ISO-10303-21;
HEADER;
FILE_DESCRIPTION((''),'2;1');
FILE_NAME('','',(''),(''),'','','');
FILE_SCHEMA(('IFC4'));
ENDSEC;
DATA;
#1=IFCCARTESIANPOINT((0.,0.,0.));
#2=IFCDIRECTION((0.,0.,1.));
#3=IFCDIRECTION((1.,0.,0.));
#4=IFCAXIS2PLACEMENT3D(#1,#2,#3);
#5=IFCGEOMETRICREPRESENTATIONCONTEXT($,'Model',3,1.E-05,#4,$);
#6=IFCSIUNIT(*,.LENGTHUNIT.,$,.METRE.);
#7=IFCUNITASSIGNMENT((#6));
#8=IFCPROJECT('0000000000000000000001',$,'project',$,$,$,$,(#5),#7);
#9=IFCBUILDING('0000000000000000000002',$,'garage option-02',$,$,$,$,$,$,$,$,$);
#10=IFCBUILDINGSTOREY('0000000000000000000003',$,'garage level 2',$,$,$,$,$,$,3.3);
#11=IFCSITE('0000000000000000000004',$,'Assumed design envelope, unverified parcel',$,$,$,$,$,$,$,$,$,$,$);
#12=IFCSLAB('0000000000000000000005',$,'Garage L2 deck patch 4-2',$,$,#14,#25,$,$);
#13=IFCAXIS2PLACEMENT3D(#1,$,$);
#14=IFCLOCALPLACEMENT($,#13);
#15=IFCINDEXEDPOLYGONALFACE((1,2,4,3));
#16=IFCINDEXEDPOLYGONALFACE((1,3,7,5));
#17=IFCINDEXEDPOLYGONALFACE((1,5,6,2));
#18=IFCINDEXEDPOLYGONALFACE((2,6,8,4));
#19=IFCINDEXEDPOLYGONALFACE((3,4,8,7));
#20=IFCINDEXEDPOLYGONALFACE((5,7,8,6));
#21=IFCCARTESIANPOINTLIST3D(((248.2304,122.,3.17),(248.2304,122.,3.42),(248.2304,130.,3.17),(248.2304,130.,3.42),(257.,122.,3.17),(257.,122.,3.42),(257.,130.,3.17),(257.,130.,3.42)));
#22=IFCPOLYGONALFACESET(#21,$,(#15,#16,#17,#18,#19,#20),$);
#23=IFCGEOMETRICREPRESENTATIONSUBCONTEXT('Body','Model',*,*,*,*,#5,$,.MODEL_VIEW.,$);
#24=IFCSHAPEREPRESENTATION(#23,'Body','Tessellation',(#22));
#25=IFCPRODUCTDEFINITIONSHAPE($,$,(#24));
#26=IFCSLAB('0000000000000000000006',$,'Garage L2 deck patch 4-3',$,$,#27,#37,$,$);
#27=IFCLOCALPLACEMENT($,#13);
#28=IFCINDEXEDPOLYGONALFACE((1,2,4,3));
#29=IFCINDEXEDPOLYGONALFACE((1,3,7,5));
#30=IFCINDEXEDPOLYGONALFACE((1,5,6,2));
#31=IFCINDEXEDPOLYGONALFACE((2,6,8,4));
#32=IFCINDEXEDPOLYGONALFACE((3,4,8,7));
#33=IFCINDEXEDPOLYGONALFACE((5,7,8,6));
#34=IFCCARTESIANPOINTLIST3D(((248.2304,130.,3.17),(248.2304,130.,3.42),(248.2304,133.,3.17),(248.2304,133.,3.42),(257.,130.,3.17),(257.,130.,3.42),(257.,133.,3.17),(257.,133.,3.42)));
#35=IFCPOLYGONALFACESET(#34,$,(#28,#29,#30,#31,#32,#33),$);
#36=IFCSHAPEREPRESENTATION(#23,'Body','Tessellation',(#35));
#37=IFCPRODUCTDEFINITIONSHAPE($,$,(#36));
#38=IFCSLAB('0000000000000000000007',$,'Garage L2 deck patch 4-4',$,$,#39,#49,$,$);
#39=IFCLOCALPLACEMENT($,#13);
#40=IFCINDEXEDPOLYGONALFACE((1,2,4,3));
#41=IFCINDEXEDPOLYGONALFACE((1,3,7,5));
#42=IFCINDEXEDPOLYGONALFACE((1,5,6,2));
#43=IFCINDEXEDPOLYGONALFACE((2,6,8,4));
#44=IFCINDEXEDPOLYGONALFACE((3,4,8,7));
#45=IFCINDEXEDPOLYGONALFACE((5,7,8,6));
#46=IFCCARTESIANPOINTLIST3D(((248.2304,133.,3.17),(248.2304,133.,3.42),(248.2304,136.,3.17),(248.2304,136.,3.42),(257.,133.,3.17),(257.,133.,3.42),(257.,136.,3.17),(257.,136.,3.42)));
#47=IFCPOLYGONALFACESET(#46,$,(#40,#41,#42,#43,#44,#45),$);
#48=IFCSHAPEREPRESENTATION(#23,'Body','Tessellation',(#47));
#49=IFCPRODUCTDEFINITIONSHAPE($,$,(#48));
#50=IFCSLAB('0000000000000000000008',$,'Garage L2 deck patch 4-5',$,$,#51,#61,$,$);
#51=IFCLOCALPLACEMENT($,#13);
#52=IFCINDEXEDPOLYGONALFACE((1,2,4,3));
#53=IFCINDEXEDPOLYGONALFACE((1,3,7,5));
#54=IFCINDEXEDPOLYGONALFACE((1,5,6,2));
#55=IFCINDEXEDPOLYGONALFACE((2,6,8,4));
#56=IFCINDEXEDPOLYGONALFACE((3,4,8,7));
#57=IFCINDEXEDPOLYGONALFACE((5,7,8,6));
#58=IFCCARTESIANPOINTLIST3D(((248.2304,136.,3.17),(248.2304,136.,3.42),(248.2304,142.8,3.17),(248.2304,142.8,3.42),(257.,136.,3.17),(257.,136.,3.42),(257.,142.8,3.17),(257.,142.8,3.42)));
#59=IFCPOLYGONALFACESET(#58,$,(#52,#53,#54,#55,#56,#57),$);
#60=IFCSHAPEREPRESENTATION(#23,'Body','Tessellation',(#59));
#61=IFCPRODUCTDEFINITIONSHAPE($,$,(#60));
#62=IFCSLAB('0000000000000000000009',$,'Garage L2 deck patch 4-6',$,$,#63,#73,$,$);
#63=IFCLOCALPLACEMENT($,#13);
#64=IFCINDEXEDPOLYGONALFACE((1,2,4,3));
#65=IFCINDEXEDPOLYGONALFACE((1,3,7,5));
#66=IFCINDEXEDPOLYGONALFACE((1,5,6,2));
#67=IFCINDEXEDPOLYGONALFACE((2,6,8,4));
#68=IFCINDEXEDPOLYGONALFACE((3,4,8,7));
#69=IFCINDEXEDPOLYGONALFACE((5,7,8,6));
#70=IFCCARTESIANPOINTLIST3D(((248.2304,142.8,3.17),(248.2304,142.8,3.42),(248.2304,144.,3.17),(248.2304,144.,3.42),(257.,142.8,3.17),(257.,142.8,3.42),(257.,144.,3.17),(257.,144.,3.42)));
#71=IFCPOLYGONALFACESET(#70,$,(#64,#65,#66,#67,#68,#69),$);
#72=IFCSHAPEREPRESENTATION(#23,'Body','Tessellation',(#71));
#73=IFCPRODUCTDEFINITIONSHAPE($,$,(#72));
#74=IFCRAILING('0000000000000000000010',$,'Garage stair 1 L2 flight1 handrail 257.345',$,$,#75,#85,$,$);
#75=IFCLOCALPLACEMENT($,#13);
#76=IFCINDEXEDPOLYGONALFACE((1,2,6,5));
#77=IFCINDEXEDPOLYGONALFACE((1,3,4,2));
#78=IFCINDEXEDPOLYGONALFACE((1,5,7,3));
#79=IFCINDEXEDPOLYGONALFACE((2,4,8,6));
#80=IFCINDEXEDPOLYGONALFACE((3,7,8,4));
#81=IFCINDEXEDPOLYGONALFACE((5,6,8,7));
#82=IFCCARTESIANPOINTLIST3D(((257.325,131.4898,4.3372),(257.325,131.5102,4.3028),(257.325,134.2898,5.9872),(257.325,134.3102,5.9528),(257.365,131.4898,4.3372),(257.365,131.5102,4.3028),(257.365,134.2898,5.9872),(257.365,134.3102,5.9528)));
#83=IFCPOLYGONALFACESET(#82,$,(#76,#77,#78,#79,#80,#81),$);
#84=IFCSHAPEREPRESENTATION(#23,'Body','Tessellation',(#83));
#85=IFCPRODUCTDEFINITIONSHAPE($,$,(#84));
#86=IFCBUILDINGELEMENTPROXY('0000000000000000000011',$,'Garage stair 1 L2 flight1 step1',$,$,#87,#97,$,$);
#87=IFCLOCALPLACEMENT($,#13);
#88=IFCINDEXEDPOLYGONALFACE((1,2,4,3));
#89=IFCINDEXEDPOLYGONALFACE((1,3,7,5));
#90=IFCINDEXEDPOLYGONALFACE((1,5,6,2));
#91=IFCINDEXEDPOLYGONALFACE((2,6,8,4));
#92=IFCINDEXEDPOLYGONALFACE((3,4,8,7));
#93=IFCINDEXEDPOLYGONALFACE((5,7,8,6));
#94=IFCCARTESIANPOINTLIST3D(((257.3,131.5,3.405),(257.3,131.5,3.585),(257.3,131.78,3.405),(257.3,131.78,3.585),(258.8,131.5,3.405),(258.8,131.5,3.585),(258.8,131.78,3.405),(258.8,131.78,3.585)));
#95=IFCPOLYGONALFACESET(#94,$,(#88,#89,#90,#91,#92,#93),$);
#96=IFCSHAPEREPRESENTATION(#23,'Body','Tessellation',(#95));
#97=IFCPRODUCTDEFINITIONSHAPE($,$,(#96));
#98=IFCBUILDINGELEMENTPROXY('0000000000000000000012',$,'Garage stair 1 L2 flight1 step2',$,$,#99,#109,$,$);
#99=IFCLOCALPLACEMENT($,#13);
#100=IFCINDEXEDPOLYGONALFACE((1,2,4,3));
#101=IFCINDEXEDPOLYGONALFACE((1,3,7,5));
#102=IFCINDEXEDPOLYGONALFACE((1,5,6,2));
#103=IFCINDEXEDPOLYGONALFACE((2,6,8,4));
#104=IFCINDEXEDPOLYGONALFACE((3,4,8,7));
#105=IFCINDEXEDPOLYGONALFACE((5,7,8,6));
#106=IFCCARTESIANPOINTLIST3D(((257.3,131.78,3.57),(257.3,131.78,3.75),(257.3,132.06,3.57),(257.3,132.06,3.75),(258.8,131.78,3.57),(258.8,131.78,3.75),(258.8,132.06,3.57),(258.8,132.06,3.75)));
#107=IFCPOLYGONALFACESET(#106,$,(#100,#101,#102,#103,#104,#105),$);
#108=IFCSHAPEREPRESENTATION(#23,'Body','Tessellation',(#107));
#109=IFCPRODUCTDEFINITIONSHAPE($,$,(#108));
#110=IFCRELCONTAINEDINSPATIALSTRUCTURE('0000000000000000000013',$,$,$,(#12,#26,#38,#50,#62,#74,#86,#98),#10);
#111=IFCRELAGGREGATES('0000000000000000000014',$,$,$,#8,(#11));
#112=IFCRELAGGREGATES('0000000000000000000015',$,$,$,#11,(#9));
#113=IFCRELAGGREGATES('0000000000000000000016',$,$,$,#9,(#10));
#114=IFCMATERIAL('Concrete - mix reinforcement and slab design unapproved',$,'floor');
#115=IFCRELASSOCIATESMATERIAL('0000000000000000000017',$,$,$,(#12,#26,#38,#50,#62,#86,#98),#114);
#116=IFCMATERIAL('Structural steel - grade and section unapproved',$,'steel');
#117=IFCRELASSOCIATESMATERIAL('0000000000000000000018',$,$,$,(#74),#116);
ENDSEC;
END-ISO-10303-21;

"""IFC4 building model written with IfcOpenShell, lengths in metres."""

from ifc_helpers import new_model, si_unit, frame, origin_with_axes, place, context, subcontext, project, spatial, rectangle, extrude, material, element, save


model = new_model("IFC4")

# Units and contexts
model_context = context("Model", 3, precision=1e-05, world=origin_with_axes())
body_context = subcontext(model_context, "Body", "Model", "MODEL_VIEW")
ifc_project = project(units=[si_unit("LENGTHUNIT", "METRE")], contexts=[model_context])

# Site, building, storey
site = spatial("IfcSite", under=ifc_project, Name="Assumed design envelope, unverified parcel")
building = spatial("IfcBuilding", under=site, Name="garage option-02")
storey = spatial("IfcBuildingStorey", under=building, Name="garage level 2", Elevation=3.3)

# Slabs
ifc_material_1 = material(Name="Concrete - mix reinforcement and slab design unapproved", Category="floor")
slab_1_placement = place(None, frame((252.6152, 126.0, 3.17), z_axis=(0.0, 0.0, 1.0), x_axis=(1.0, 0.0, 0.0)))
element("IfcSlab", 1, at=slab_1_placement, inside=storey, material=ifc_material_1, Name="Garage L2 deck patch 4-2", context=body_context, shape_type="SweptSolid", body=[
    extrude(rectangle(XDim=8.7696, YDim=8.0), origin_with_axes(), (0.0, 0.0, 1.0), 0.25),
])
for number, where, z_axis, x_axis, name in (
    (2, (252.6152, 131.5, 3.17), (0.0, 0.0, 1.0), (1.0, 0.0, 0.0), "Garage L2 deck patch 4-3"),
    (3, (252.6152, 134.5, 3.17), (0.0, 0.0, 1.0), (1.0, 0.0, 0.0), "Garage L2 deck patch 4-4"),
):
    element("IfcSlab", number, at=place(None, frame(where, z_axis=z_axis, x_axis=x_axis)), inside=storey, material=ifc_material_1, Name=name, context=body_context, shape_type="SweptSolid", body=[
        extrude(rectangle(XDim=8.7696, YDim=3.0), origin_with_axes(), (0.0, 0.0, 1.0), 0.25),
    ])
slab_2_placement = place(None, frame((252.6152, 139.4, 3.17), z_axis=(0.0, 0.0, 1.0), x_axis=(1.0, 0.0, 0.0)))
element("IfcSlab", 4, at=slab_2_placement, inside=storey, material=ifc_material_1, Name="Garage L2 deck patch 4-5", context=body_context, shape_type="SweptSolid", body=[
    extrude(rectangle(XDim=8.7696, YDim=6.8), origin_with_axes(), (0.0, 0.0, 1.0), 0.25),
])
slab_3_placement = place(None, frame((252.6152, 143.4, 3.17), z_axis=(0.0, 0.0, 1.0), x_axis=(1.0, 0.0, 0.0)))
element("IfcSlab", 5, at=slab_3_placement, inside=storey, material=ifc_material_1, Name="Garage L2 deck patch 4-6", context=body_context, shape_type="SweptSolid", body=[
    extrude(rectangle(XDim=8.7696, YDim=1.2), origin_with_axes(), (0.0, 0.0, 1.0), 0.25),
])

# Railing
ifc_material_2 = material(Name="Structural steel - grade and section unapproved", Category="steel")
railing_placement = place(None, frame((257.345, 131.5, 4.32), z_axis=(0.0, 0.861539, 0.507692), x_axis=(-1.0, 0.0, 0.0)))
element("IfcRailing", 6, at=railing_placement, inside=storey, material=ifc_material_2, Name="Garage stair 1 L2 flight1 handrail 257.345", context=body_context, shape_type="SweptSolid", body=[
    extrude(rectangle(XDim=0.04, YDim=0.04), origin_with_axes(), (0.0, 0.0, 1.0), 3.25),
])

# Building element proxies
for number, where, z_axis, x_axis, name in (
    (7, (258.05, 131.64, 3.405), (0.0, 0.0, 1.0), (1.0, 0.0, 0.0), "Garage stair 1 L2 flight1 step1"),
    (8, (258.05, 131.92, 3.57), (0.0, 0.0, 1.0), (1.0, 0.0, 0.0), "Garage stair 1 L2 flight1 step2"),
):
    element("IfcBuildingElementProxy", number, at=place(None, frame(where, z_axis=z_axis, x_axis=x_axis)), inside=storey, material=ifc_material_1, Name=name, context=body_context, shape_type="SweptSolid", body=[
        extrude(rectangle(XDim=1.5, YDim=0.28), origin_with_axes(), (0.0, 0.0, 1.0), 0.18),
    ])

save(model, "model.ifc")
